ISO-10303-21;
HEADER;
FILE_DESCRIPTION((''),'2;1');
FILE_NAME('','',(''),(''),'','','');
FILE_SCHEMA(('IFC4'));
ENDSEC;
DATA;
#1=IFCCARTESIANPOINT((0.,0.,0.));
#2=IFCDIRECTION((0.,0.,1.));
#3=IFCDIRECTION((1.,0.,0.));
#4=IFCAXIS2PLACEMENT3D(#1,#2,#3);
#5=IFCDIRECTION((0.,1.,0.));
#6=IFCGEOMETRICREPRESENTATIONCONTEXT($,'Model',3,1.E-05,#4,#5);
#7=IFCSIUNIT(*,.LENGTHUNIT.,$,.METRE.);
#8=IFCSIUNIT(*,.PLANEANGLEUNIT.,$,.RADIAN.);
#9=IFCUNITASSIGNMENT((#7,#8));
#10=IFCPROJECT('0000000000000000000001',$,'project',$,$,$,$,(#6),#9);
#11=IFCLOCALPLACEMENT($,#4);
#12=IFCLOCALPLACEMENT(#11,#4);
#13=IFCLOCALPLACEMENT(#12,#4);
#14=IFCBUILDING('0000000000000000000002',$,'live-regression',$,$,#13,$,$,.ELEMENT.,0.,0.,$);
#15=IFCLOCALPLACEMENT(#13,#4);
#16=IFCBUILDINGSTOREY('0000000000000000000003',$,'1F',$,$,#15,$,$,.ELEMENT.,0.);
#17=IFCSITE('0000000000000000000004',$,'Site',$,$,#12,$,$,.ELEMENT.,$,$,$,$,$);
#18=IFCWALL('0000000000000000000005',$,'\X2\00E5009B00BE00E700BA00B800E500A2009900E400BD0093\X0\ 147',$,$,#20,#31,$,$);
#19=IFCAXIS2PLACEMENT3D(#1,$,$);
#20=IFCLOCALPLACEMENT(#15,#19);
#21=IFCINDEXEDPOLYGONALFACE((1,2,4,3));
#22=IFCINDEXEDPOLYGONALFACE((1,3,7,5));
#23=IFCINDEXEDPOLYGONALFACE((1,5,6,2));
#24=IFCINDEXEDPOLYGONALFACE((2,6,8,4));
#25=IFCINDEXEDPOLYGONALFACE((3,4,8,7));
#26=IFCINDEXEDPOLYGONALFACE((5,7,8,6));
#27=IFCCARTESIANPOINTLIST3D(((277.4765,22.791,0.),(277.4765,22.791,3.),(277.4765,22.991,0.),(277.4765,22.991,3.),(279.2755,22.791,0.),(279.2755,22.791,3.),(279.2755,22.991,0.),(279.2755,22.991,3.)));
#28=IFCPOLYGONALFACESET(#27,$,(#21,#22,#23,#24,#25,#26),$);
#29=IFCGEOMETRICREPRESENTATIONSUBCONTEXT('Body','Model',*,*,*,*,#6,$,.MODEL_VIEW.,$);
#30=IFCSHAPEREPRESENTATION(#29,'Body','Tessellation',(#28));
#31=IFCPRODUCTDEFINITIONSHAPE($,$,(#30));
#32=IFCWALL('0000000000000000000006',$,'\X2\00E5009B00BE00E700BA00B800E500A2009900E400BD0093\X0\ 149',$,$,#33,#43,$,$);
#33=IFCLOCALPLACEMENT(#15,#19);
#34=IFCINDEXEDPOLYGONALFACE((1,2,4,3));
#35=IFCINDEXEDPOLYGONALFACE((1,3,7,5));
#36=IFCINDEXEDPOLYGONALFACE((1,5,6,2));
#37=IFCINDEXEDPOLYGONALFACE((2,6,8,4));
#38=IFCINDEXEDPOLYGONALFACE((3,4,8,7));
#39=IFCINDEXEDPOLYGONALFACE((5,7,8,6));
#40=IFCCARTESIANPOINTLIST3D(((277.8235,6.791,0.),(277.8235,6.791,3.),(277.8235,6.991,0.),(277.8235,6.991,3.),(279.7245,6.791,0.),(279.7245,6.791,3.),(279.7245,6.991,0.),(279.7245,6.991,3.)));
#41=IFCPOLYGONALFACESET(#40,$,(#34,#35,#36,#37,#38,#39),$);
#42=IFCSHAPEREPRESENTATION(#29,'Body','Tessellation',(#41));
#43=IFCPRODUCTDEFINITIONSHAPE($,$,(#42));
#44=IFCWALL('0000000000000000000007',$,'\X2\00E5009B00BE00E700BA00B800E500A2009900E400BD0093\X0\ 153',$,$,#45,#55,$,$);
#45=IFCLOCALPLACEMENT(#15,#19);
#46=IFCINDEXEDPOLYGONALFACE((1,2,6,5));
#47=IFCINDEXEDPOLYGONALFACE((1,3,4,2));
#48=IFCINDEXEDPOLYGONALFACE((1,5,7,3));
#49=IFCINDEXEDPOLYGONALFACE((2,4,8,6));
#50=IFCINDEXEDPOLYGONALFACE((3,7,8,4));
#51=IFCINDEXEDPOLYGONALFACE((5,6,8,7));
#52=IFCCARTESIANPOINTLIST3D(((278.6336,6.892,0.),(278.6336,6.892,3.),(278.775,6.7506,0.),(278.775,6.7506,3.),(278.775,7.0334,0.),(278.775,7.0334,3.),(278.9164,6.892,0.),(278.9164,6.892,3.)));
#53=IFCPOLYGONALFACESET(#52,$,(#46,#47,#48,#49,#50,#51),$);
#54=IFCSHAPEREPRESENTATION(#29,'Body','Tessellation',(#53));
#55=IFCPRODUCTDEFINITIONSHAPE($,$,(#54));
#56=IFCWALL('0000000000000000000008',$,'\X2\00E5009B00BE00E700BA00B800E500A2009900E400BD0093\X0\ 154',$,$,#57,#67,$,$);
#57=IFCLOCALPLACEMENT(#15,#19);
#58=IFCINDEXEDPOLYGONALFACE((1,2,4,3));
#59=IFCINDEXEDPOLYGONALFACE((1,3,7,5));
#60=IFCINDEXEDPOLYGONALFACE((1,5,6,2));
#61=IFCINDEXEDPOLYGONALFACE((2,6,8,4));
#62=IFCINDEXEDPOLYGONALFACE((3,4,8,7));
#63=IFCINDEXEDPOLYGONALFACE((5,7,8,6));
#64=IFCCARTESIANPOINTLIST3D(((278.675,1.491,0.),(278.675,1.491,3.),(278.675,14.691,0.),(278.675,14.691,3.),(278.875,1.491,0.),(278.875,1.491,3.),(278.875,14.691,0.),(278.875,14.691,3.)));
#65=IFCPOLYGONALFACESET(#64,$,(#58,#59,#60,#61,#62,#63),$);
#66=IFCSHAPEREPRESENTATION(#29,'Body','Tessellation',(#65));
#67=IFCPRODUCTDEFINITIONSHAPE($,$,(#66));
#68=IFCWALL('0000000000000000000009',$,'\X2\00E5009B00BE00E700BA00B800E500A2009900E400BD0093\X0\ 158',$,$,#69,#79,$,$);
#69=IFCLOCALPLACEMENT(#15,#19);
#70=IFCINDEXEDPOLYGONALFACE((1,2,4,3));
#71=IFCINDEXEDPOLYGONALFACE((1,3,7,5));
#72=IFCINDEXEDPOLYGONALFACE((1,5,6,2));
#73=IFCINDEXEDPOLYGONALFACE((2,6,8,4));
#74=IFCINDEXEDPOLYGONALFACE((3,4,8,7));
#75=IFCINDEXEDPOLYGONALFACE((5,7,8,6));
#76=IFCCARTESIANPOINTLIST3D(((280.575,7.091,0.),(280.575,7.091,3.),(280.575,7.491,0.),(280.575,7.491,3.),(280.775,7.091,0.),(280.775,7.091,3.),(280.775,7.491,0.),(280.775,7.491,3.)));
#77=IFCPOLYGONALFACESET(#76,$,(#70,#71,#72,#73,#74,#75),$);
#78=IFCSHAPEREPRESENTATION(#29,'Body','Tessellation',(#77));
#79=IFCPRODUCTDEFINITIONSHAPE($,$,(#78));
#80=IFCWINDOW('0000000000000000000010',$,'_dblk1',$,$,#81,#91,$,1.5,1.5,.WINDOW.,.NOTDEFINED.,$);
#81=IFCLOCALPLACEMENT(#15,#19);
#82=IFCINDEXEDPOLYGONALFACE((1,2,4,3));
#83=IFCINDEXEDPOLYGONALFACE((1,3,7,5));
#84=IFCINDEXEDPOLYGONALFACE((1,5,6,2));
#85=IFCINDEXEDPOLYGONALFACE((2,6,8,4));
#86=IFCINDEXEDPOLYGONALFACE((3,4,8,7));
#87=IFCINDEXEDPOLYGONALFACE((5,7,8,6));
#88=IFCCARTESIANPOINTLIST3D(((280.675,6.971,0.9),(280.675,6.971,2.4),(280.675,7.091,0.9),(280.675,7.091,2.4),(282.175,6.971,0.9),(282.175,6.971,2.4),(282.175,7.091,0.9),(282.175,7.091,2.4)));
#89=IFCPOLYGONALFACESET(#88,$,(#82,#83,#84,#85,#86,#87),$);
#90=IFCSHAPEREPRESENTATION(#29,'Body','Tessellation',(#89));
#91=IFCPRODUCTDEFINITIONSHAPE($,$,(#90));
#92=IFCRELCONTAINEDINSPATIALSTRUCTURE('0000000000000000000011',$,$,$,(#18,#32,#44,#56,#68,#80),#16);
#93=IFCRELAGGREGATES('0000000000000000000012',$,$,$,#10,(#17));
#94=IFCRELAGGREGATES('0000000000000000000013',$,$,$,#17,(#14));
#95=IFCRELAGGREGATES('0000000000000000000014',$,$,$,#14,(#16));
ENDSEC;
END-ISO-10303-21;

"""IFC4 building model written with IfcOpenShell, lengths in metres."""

from ifc_helpers import new_model, si_unit, direction, frame, frame_2d, origin_with_axes, place, context, subcontext, project, spatial, rectangle, extrude, element, save


model = new_model("IFC4")

# Units and contexts
model_context = context("Model", 3, precision=1e-05, world=origin_with_axes(), true_north=direction((0.0, 1.0, 0.0)))
body_context = subcontext(model_context, "Body", "Model", "MODEL_VIEW")
ifc_project = project(units=[si_unit("LENGTHUNIT", "METRE"), si_unit("PLANEANGLEUNIT", "RADIAN")], contexts=[model_context])

# Site, building, storey
placement = place(None, origin_with_axes())
site_placement = place(placement, origin_with_axes())
site = spatial("IfcSite", under=ifc_project, at=site_placement, Name="Site", CompositionType="ELEMENT")
building_placement = place(site_placement, origin_with_axes())
building = spatial("IfcBuilding", under=site, at=building_placement, Name="live-regression", CompositionType="ELEMENT", ElevationOfRefHeight=0.0, ElevationOfTerrain=0.0)
storey_placement = place(building_placement, origin_with_axes())
storey = spatial("IfcBuildingStorey", under=building, at=storey_placement, Name="1F", CompositionType="ELEMENT", Elevation=0.0)

# Walls
wall_1_placement = place(storey_placement, frame((278.376, 22.891, 0.0), z_axis=(0.0, 0.0, 1.0), x_axis=(1.0, 0.0, 0.0)))
element("IfcWall", 1, at=wall_1_placement, inside=storey, Name="å\u009b¾çº¸å¢\u0099ä½\u0093 147", context=body_context, shape_type="SweptSolid", body=[
    extrude(rectangle(XDim=1.799, YDim=0.2, at=frame_2d((0.0, 0.0), x_axis=(1.0, 0.0, 0.0))), frame((0.0, 0.0, 0.0), z_axis=(0.0, 0.0, 1.0)), (0.0, 0.0, 1.0), 3.0),
])
wall_2_placement = place(storey_placement, frame((278.774, 6.891, 0.0), z_axis=(0.0, 0.0, 1.0), x_axis=(1.0, 0.0, 0.0)))
element("IfcWall", 2, at=wall_2_placement, inside=storey, Name="å\u009b¾çº¸å¢\u0099ä½\u0093 149", context=body_context, shape_type="SweptSolid", body=[
    extrude(rectangle(XDim=1.901, YDim=0.2, at=frame_2d((0.0, 0.0), x_axis=(1.0, 0.0, 0.0))), frame((0.0, 0.0, 0.0), z_axis=(0.0, 0.0, 1.0)), (0.0, 0.0, 1.0), 3.0),
])
wall_3_placement = place(storey_placement, frame((278.775, 6.892, 0.0), z_axis=(0.0, 0.0, 1.0), x_axis=(-0.707107, -0.707107, 0.0)))
element("IfcWall", 3, at=wall_3_placement, inside=storey, Name="å\u009b¾çº¸å¢\u0099ä½\u0093 153", context=body_context, shape_type="SweptSolid", body=[
    extrude(rectangle(XDim=0.2, YDim=0.2, at=frame_2d((0.0, 0.0), x_axis=(1.0, 0.0, 0.0))), frame((0.0, 0.0, 0.0), z_axis=(0.0, 0.0, 1.0)), (0.0, 0.0, 1.0), 3.0),
])
wall_4_placement = place(storey_placement, frame((278.775, 8.091, 0.0), z_axis=(0.0, 0.0, 1.0), x_axis=(0.0, 1.0, 0.0)))
element("IfcWall", 4, at=wall_4_placement, inside=storey, Name="å\u009b¾çº¸å¢\u0099ä½\u0093 154", context=body_context, shape_type="SweptSolid", body=[
    extrude(rectangle(XDim=13.2, YDim=0.2, at=frame_2d((0.0, 0.0), x_axis=(1.0, 0.0, 0.0))), frame((0.0, 0.0, 0.0), z_axis=(0.0, 0.0, 1.0)), (0.0, 0.0, 1.0), 3.0),
])
wall_5_placement = place(storey_placement, frame((280.675, 7.291, 0.0), z_axis=(0.0, 0.0, 1.0), x_axis=(0.0, -1.0, 0.0)))
element("IfcWall", 5, at=wall_5_placement, inside=storey, Name="å\u009b¾çº¸å¢\u0099ä½\u0093 158", context=body_context, shape_type="SweptSolid", body=[
    extrude(rectangle(XDim=0.4, YDim=0.2, at=frame_2d((0.0, 0.0), x_axis=(1.0, 0.0, 0.0))), frame((0.0, 0.0, 0.0), z_axis=(0.0, 0.0, 1.0)), (0.0, 0.0, 1.0), 3.0),
])

# Window
window_placement = place(storey_placement, frame((281.425, 7.031, 0.9), z_axis=(0.0, 0.0, 1.0), x_axis=(1.0, 0.0, 0.0)))
element("IfcWindow", 6, at=window_placement, inside=storey, Name="_dblk1", OverallHeight=1.5, OverallWidth=1.5, PartitioningType="NOTDEFINED", PredefinedType="WINDOW", context=body_context, shape_type="SweptSolid", body=[
    extrude(rectangle(XDim=1.5, YDim=0.12, at=frame_2d((0.0, 0.0), x_axis=(1.0, 0.0, 0.0))), frame((0.0, 0.0, 0.0), z_axis=(0.0, 0.0, 1.0)), (0.0, 0.0, 1.0), 1.5),
])

save(model, "model.ifc")
